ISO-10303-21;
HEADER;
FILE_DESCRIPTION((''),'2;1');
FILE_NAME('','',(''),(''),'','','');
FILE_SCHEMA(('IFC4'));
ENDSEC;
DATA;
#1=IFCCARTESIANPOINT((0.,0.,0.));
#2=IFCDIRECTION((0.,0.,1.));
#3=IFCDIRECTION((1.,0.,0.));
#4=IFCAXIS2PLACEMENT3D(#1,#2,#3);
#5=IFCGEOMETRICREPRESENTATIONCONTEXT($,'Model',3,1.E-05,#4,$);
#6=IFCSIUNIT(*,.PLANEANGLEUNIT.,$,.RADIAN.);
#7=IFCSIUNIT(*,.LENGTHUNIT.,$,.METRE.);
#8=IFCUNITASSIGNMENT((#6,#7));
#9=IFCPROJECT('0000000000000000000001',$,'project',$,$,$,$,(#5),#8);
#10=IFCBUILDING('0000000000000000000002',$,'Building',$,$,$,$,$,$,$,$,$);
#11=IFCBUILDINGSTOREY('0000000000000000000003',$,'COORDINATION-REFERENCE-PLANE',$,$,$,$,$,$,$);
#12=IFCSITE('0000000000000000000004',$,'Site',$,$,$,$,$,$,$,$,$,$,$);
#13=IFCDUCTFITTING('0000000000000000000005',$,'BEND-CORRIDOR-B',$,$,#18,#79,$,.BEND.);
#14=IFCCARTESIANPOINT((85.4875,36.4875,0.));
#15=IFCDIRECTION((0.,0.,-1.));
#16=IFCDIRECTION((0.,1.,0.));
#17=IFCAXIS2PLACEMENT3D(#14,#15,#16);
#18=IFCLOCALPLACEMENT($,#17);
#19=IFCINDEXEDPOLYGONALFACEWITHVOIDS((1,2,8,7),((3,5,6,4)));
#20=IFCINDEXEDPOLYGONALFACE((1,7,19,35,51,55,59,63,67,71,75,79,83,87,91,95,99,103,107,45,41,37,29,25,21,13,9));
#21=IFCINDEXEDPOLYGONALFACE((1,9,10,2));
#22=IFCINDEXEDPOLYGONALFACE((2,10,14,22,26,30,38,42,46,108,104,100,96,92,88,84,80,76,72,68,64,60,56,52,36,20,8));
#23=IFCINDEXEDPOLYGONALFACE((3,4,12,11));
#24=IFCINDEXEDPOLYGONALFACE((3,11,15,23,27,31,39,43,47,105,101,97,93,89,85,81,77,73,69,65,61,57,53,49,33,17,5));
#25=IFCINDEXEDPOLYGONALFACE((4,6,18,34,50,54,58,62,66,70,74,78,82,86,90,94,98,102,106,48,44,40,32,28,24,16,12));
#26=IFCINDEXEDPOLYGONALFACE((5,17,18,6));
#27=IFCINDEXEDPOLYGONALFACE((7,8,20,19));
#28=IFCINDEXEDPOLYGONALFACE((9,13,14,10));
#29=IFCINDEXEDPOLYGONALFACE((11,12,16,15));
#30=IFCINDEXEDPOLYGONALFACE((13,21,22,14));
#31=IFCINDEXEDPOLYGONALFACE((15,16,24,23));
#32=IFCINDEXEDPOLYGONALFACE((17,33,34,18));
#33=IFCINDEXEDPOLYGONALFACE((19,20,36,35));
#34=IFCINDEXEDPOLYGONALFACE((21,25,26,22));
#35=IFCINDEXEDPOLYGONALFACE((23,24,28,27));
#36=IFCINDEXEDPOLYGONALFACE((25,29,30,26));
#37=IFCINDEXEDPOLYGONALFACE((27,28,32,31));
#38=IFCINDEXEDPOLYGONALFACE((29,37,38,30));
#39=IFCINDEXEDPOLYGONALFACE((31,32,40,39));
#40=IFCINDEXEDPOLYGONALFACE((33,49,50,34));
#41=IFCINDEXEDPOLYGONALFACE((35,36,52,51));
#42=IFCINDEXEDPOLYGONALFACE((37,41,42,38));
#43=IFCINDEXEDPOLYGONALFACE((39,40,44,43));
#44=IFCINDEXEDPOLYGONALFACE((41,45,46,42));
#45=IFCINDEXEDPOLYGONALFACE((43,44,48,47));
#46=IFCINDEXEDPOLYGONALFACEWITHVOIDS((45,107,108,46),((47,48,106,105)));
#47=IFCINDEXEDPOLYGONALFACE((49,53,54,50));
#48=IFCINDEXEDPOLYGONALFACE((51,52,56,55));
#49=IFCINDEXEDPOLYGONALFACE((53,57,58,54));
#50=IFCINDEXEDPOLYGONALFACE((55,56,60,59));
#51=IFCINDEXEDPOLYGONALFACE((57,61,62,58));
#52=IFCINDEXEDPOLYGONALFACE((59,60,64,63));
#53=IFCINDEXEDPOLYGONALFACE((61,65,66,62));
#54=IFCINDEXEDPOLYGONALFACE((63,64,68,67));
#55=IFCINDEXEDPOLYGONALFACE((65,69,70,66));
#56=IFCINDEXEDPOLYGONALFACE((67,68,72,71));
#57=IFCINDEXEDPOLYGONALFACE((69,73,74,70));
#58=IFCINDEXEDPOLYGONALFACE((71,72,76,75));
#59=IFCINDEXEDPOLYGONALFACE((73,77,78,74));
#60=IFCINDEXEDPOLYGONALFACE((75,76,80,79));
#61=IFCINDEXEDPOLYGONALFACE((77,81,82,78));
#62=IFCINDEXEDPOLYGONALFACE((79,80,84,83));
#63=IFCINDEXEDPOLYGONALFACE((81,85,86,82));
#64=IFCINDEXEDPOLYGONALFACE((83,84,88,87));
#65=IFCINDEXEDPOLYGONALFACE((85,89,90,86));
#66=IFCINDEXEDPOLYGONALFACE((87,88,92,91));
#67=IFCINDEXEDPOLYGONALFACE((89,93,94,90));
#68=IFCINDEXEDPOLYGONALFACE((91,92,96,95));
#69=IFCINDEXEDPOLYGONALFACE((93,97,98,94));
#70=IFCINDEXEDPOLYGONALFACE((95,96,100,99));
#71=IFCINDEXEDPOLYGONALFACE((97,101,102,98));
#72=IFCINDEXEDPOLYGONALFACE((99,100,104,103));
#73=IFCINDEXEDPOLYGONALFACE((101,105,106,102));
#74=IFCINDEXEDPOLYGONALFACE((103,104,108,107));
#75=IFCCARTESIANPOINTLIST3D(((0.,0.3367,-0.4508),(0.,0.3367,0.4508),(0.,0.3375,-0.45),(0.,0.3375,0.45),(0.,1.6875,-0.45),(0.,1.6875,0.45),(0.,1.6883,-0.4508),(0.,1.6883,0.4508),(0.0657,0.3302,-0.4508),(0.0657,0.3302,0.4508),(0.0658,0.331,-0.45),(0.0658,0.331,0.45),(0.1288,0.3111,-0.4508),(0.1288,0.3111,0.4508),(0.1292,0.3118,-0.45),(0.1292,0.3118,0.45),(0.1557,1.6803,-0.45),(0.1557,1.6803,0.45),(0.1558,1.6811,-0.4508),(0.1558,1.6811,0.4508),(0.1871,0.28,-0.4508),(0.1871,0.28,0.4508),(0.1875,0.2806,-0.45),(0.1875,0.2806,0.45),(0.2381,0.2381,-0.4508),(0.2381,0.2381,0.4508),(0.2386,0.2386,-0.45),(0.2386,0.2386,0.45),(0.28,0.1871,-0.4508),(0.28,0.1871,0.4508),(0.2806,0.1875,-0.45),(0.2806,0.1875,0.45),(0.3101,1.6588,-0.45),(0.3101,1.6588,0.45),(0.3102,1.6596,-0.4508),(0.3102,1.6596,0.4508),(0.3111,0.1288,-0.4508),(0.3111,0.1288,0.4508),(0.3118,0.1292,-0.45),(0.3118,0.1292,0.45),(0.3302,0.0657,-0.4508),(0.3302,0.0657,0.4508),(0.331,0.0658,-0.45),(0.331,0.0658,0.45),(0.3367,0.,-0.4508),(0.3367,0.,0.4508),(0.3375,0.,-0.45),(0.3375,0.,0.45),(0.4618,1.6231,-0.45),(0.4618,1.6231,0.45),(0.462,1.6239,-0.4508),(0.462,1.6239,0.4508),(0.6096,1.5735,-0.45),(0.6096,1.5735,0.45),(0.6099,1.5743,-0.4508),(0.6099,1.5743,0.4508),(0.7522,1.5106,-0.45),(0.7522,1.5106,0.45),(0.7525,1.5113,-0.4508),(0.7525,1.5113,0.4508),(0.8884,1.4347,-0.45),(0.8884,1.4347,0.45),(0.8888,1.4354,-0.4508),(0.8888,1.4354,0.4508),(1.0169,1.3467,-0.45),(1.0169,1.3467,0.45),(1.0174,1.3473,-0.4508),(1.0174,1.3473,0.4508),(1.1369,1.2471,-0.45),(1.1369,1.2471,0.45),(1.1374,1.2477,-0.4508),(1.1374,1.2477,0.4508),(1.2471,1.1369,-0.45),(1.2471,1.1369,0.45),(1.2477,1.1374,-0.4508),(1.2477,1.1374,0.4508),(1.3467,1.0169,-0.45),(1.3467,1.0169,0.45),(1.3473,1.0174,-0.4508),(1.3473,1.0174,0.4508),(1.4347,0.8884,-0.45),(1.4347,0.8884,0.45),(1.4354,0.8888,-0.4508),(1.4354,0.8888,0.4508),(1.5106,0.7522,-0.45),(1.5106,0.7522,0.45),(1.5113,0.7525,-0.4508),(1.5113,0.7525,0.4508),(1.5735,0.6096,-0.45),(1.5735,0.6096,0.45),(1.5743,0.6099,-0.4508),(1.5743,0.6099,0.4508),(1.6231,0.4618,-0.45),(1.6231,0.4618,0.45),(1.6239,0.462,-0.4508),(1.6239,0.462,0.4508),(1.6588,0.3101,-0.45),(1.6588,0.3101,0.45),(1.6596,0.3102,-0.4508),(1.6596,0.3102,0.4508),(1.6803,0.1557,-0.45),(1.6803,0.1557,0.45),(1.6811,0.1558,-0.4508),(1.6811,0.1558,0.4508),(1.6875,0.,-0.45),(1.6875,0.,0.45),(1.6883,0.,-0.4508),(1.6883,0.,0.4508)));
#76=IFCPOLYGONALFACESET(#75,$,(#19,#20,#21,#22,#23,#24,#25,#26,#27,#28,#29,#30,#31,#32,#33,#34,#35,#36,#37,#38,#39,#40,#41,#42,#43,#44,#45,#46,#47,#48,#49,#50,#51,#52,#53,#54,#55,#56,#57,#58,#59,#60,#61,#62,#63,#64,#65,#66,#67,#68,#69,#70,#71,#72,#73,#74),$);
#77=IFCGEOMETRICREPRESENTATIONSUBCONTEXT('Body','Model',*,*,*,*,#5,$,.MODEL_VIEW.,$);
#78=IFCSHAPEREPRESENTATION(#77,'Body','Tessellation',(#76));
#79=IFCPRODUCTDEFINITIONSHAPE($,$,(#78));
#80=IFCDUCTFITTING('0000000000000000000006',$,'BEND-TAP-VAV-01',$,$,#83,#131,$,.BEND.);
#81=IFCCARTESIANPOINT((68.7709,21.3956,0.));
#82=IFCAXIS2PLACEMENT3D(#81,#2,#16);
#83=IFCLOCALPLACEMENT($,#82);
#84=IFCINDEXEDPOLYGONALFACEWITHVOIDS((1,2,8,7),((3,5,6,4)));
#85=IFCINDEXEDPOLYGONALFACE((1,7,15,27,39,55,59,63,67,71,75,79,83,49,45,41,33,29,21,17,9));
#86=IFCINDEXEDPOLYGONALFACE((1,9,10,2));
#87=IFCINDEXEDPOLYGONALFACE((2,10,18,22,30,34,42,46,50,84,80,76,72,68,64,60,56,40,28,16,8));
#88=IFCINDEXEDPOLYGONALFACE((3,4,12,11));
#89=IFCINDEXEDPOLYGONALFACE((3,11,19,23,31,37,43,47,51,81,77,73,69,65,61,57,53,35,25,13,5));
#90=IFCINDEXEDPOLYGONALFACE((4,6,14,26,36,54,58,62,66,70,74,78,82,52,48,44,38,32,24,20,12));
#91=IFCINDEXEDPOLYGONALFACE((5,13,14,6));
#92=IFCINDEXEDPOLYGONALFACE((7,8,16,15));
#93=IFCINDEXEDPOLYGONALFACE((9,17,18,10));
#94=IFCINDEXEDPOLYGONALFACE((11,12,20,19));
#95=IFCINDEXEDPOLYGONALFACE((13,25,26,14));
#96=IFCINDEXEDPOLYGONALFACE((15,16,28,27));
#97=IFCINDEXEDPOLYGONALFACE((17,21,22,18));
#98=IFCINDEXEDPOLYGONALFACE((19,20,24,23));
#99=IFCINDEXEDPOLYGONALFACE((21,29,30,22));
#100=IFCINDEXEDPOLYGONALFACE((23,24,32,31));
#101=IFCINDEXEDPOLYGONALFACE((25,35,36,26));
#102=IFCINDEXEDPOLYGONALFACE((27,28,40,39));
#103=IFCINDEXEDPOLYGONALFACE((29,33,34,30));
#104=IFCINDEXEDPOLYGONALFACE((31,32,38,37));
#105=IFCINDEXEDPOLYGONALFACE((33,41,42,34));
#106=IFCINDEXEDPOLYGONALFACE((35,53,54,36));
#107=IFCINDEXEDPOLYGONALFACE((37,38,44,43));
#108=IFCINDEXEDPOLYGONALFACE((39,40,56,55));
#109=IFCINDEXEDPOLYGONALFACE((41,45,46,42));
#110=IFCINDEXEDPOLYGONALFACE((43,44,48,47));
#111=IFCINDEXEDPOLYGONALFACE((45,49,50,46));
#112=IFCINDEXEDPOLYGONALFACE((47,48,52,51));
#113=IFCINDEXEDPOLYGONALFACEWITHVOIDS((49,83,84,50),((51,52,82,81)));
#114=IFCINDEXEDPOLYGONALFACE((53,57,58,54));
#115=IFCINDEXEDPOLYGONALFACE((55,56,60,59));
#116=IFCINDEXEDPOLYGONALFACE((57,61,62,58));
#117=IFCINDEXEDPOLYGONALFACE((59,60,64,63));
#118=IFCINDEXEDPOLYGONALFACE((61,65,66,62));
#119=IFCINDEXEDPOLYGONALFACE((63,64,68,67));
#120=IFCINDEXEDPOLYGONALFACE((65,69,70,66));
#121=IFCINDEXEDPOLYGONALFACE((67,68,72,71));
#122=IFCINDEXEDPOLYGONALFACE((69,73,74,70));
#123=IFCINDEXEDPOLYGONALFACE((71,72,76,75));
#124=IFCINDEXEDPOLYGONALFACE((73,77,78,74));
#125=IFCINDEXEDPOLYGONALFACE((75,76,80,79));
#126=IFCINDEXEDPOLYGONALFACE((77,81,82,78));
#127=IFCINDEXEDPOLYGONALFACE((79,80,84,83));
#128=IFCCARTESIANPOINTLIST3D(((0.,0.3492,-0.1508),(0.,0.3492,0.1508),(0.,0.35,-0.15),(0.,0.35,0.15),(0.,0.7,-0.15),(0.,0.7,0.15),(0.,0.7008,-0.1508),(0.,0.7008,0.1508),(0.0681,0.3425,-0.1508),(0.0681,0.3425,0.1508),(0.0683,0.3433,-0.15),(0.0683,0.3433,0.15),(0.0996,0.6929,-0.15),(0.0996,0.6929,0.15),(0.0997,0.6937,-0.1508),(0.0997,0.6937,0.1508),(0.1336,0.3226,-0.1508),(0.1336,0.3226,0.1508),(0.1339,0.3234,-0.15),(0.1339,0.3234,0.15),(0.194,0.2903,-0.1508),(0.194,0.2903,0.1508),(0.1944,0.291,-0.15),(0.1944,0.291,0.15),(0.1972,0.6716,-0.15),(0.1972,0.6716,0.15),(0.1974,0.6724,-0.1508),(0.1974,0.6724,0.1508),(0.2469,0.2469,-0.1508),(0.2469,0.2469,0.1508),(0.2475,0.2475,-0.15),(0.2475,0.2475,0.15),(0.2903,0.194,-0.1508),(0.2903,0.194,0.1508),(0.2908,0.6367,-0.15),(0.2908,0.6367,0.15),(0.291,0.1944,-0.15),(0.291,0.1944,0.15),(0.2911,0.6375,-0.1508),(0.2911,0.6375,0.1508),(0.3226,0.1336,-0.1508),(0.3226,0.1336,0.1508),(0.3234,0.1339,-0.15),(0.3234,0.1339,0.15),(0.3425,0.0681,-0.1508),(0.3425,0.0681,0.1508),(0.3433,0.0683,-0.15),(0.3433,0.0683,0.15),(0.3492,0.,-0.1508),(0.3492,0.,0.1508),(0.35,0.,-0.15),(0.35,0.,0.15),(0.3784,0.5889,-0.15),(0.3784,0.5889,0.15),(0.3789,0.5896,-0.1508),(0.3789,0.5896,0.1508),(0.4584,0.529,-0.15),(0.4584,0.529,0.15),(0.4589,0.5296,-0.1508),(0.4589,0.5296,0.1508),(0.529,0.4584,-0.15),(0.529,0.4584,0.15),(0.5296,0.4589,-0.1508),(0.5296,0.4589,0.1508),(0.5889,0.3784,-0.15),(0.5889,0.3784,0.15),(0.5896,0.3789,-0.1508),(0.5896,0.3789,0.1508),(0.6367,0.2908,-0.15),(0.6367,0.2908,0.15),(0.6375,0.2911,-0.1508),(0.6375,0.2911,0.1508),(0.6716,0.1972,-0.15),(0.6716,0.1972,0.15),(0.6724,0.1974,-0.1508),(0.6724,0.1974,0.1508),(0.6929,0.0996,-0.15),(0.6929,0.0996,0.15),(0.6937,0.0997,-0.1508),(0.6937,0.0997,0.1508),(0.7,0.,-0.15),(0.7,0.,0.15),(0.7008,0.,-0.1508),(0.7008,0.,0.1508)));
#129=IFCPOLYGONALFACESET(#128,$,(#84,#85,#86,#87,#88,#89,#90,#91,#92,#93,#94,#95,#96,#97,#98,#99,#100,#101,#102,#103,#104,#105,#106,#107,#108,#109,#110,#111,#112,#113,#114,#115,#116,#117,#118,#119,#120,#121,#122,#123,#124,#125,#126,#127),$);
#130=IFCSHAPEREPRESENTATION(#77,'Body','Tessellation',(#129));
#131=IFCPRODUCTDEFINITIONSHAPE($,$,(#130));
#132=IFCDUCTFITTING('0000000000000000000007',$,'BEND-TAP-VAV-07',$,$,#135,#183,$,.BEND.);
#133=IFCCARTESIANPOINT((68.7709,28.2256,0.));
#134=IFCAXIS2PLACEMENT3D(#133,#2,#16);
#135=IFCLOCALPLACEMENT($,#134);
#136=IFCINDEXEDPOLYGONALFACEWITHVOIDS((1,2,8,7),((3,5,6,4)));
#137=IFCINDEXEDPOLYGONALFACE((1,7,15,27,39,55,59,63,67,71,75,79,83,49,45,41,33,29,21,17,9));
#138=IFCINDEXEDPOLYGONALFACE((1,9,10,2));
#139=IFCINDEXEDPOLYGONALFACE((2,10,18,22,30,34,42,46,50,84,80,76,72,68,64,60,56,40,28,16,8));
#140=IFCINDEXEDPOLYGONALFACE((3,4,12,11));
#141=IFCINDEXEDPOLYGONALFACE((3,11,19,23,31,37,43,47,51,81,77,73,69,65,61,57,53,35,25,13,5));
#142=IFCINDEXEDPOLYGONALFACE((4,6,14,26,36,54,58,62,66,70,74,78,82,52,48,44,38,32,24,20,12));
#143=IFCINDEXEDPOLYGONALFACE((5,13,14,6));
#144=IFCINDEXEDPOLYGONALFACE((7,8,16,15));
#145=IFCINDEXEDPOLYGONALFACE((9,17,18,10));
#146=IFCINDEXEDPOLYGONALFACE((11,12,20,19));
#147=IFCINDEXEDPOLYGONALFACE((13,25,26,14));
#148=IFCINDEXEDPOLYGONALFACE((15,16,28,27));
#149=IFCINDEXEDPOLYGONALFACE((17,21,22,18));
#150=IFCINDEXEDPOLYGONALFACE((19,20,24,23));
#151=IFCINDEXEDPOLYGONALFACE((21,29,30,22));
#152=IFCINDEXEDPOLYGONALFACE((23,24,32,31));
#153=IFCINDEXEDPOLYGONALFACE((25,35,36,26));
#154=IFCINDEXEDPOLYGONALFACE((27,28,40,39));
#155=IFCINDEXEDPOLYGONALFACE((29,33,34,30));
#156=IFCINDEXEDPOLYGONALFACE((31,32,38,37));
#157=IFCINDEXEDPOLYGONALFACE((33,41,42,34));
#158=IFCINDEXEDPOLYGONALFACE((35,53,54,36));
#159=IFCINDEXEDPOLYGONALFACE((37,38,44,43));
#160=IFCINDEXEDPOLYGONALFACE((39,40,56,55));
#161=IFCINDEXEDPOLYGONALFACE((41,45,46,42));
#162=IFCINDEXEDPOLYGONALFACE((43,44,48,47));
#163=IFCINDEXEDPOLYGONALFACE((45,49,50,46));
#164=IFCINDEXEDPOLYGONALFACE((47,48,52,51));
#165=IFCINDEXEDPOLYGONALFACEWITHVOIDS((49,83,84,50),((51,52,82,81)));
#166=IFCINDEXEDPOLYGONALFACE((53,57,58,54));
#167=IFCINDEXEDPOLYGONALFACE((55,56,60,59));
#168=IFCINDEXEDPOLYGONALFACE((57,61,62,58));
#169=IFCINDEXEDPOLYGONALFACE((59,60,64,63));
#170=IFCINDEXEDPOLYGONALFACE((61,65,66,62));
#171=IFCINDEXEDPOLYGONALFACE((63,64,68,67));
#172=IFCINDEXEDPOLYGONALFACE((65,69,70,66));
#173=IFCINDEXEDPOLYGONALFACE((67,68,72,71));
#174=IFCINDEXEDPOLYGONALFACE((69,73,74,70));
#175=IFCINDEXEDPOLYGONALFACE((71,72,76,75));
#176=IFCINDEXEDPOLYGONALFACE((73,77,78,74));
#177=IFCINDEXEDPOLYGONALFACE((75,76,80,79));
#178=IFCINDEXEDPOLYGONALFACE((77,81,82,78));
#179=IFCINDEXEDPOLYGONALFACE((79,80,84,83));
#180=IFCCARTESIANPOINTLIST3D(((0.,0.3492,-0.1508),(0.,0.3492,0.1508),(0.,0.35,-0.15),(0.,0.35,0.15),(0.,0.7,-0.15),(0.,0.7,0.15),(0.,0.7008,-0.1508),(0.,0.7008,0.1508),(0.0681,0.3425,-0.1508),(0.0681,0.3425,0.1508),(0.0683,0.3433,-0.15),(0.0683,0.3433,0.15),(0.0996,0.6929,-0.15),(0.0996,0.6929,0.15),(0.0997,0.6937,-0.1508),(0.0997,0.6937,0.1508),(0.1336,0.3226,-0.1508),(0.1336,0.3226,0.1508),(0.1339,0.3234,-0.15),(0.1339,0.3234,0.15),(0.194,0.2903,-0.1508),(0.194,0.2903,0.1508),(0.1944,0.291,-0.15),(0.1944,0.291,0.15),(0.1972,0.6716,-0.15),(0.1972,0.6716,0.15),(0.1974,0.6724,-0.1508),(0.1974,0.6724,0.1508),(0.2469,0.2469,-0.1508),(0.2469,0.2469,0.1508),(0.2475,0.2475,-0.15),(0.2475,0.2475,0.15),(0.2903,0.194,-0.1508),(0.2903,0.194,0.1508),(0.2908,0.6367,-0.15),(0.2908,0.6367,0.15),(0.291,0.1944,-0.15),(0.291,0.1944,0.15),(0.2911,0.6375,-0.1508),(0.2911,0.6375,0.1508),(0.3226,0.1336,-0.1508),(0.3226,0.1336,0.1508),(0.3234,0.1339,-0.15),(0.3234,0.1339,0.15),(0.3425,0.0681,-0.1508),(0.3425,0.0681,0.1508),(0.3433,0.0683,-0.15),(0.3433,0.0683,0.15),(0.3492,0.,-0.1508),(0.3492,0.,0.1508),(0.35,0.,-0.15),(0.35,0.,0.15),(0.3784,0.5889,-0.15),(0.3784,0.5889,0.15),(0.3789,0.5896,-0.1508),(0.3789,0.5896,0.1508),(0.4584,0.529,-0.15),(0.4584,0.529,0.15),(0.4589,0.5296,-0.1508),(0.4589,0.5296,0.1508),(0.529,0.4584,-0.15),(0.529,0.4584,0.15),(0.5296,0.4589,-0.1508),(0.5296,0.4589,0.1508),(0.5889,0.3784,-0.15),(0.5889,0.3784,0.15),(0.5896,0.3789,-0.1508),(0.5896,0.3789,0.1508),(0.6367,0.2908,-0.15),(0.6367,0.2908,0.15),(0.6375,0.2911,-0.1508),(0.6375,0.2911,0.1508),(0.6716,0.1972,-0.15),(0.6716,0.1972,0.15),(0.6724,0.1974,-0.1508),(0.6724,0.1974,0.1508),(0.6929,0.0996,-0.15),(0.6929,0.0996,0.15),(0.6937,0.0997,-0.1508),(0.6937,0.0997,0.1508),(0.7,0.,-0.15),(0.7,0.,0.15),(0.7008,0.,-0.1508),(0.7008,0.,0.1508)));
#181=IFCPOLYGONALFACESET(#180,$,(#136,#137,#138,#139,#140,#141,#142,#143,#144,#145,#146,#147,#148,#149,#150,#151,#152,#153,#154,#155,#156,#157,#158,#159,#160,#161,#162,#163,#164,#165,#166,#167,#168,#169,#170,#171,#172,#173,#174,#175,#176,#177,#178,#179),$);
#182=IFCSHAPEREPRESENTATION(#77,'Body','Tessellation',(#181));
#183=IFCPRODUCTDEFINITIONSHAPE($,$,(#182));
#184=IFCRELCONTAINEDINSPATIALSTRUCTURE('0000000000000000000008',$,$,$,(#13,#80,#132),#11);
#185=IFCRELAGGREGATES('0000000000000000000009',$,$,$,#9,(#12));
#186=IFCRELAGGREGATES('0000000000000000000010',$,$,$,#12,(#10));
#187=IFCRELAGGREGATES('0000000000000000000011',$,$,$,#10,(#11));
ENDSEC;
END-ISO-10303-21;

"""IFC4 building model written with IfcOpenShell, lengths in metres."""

from ifc_helpers import new_model, entity, si_unit, frame, origin_with_axes, place, context, subcontext, project, spatial, element, save


model = new_model("IFC4")

# Units and contexts
model_context = context("Model", 3, precision=1e-05, world=origin_with_axes())
body_context = subcontext(model_context, "Body", "Model", "MODEL_VIEW")
ifc_project = project(units=[si_unit("PLANEANGLEUNIT", "RADIAN"), si_unit("LENGTHUNIT", "METRE")], contexts=[model_context])

# Site, building, storey
site = spatial("IfcSite", under=ifc_project, Name="Site")
building = spatial("IfcBuilding", under=site, Name="Building")
storey = spatial("IfcBuildingStorey", under=building, Name="COORDINATION-REFERENCE-PLANE")

# Duct fittings
duct_fitting_1_placement = place(None, frame((85.4875, 36.4875, 0.0), z_axis=(0.0, 0.0, -1.0), x_axis=(0.0, 1.0, 0.0)))
cartesian_point_1 = entity("IfcCartesianPoint", [0.0, 0.0, 0.0])
element("IfcDuctFitting", 1, at=duct_fitting_1_placement, inside=storey, Name="BEND-CORRIDOR-B", PredefinedType="BEND", context=body_context, shape_type="SweptSolid", body=[
    entity("IfcRevolvedAreaSolid", entity("IfcRectangleHollowProfileDef", "AREA", None, entity("IfcAxis2Placement2D", entity("IfcCartesianPoint", [1.0125, 0.0])), 1.3516, 0.9016, 0.0008), entity("IfcAxis2Placement3D", cartesian_point_1, entity("IfcDirection", [0.0, -1.0, 0.0]), entity("IfcDirection", [1.0, 0.0, 0.0])), entity("IfcAxis1Placement", cartesian_point_1, entity("IfcDirection", [0.0, 1.0, 0.0])), 1.570796),
])
duct_fitting_2_placement = place(None, frame((68.7709, 21.3956, 0.0), z_axis=(0.0, 0.0, 1.0), x_axis=(0.0, 1.0, 0.0)))
cartesian_point_2 = entity("IfcCartesianPoint", [0.0, 0.0, 0.0])
element("IfcDuctFitting", 2, at=duct_fitting_2_placement, inside=storey, Name="BEND-TAP-VAV-01", PredefinedType="BEND", context=body_context, shape_type="SweptSolid", body=[
    entity("IfcRevolvedAreaSolid", entity("IfcRectangleHollowProfileDef", "AREA", None, entity("IfcAxis2Placement2D", entity("IfcCartesianPoint", [0.525, 0.0])), 0.3516, 0.3016, 0.0008), entity("IfcAxis2Placement3D", cartesian_point_2, entity("IfcDirection", [0.0, -1.0, 0.0]), entity("IfcDirection", [1.0, 0.0, 0.0])), entity("IfcAxis1Placement", cartesian_point_2, entity("IfcDirection", [0.0, 1.0, 0.0])), 1.570796),
])
duct_fitting_3_placement = place(None, frame((68.7709, 28.2256, 0.0), z_axis=(0.0, 0.0, 1.0), x_axis=(0.0, 1.0, 0.0)))
cartesian_point_3 = entity("IfcCartesianPoint", [0.0, 0.0, 0.0])
element("IfcDuctFitting", 3, at=duct_fitting_3_placement, inside=storey, Name="BEND-TAP-VAV-07", PredefinedType="BEND", context=body_context, shape_type="SweptSolid", body=[
    entity("IfcRevolvedAreaSolid", entity("IfcRectangleHollowProfileDef", "AREA", None, entity("IfcAxis2Placement2D", entity("IfcCartesianPoint", [0.525, 0.0])), 0.3516, 0.3016, 0.0008), entity("IfcAxis2Placement3D", cartesian_point_3, entity("IfcDirection", [0.0, -1.0, 0.0]), entity("IfcDirection", [1.0, 0.0, 0.0])), entity("IfcAxis1Placement", cartesian_point_3, entity("IfcDirection", [0.0, 1.0, 0.0])), 1.570796),
])

save(model, "model.ifc")
